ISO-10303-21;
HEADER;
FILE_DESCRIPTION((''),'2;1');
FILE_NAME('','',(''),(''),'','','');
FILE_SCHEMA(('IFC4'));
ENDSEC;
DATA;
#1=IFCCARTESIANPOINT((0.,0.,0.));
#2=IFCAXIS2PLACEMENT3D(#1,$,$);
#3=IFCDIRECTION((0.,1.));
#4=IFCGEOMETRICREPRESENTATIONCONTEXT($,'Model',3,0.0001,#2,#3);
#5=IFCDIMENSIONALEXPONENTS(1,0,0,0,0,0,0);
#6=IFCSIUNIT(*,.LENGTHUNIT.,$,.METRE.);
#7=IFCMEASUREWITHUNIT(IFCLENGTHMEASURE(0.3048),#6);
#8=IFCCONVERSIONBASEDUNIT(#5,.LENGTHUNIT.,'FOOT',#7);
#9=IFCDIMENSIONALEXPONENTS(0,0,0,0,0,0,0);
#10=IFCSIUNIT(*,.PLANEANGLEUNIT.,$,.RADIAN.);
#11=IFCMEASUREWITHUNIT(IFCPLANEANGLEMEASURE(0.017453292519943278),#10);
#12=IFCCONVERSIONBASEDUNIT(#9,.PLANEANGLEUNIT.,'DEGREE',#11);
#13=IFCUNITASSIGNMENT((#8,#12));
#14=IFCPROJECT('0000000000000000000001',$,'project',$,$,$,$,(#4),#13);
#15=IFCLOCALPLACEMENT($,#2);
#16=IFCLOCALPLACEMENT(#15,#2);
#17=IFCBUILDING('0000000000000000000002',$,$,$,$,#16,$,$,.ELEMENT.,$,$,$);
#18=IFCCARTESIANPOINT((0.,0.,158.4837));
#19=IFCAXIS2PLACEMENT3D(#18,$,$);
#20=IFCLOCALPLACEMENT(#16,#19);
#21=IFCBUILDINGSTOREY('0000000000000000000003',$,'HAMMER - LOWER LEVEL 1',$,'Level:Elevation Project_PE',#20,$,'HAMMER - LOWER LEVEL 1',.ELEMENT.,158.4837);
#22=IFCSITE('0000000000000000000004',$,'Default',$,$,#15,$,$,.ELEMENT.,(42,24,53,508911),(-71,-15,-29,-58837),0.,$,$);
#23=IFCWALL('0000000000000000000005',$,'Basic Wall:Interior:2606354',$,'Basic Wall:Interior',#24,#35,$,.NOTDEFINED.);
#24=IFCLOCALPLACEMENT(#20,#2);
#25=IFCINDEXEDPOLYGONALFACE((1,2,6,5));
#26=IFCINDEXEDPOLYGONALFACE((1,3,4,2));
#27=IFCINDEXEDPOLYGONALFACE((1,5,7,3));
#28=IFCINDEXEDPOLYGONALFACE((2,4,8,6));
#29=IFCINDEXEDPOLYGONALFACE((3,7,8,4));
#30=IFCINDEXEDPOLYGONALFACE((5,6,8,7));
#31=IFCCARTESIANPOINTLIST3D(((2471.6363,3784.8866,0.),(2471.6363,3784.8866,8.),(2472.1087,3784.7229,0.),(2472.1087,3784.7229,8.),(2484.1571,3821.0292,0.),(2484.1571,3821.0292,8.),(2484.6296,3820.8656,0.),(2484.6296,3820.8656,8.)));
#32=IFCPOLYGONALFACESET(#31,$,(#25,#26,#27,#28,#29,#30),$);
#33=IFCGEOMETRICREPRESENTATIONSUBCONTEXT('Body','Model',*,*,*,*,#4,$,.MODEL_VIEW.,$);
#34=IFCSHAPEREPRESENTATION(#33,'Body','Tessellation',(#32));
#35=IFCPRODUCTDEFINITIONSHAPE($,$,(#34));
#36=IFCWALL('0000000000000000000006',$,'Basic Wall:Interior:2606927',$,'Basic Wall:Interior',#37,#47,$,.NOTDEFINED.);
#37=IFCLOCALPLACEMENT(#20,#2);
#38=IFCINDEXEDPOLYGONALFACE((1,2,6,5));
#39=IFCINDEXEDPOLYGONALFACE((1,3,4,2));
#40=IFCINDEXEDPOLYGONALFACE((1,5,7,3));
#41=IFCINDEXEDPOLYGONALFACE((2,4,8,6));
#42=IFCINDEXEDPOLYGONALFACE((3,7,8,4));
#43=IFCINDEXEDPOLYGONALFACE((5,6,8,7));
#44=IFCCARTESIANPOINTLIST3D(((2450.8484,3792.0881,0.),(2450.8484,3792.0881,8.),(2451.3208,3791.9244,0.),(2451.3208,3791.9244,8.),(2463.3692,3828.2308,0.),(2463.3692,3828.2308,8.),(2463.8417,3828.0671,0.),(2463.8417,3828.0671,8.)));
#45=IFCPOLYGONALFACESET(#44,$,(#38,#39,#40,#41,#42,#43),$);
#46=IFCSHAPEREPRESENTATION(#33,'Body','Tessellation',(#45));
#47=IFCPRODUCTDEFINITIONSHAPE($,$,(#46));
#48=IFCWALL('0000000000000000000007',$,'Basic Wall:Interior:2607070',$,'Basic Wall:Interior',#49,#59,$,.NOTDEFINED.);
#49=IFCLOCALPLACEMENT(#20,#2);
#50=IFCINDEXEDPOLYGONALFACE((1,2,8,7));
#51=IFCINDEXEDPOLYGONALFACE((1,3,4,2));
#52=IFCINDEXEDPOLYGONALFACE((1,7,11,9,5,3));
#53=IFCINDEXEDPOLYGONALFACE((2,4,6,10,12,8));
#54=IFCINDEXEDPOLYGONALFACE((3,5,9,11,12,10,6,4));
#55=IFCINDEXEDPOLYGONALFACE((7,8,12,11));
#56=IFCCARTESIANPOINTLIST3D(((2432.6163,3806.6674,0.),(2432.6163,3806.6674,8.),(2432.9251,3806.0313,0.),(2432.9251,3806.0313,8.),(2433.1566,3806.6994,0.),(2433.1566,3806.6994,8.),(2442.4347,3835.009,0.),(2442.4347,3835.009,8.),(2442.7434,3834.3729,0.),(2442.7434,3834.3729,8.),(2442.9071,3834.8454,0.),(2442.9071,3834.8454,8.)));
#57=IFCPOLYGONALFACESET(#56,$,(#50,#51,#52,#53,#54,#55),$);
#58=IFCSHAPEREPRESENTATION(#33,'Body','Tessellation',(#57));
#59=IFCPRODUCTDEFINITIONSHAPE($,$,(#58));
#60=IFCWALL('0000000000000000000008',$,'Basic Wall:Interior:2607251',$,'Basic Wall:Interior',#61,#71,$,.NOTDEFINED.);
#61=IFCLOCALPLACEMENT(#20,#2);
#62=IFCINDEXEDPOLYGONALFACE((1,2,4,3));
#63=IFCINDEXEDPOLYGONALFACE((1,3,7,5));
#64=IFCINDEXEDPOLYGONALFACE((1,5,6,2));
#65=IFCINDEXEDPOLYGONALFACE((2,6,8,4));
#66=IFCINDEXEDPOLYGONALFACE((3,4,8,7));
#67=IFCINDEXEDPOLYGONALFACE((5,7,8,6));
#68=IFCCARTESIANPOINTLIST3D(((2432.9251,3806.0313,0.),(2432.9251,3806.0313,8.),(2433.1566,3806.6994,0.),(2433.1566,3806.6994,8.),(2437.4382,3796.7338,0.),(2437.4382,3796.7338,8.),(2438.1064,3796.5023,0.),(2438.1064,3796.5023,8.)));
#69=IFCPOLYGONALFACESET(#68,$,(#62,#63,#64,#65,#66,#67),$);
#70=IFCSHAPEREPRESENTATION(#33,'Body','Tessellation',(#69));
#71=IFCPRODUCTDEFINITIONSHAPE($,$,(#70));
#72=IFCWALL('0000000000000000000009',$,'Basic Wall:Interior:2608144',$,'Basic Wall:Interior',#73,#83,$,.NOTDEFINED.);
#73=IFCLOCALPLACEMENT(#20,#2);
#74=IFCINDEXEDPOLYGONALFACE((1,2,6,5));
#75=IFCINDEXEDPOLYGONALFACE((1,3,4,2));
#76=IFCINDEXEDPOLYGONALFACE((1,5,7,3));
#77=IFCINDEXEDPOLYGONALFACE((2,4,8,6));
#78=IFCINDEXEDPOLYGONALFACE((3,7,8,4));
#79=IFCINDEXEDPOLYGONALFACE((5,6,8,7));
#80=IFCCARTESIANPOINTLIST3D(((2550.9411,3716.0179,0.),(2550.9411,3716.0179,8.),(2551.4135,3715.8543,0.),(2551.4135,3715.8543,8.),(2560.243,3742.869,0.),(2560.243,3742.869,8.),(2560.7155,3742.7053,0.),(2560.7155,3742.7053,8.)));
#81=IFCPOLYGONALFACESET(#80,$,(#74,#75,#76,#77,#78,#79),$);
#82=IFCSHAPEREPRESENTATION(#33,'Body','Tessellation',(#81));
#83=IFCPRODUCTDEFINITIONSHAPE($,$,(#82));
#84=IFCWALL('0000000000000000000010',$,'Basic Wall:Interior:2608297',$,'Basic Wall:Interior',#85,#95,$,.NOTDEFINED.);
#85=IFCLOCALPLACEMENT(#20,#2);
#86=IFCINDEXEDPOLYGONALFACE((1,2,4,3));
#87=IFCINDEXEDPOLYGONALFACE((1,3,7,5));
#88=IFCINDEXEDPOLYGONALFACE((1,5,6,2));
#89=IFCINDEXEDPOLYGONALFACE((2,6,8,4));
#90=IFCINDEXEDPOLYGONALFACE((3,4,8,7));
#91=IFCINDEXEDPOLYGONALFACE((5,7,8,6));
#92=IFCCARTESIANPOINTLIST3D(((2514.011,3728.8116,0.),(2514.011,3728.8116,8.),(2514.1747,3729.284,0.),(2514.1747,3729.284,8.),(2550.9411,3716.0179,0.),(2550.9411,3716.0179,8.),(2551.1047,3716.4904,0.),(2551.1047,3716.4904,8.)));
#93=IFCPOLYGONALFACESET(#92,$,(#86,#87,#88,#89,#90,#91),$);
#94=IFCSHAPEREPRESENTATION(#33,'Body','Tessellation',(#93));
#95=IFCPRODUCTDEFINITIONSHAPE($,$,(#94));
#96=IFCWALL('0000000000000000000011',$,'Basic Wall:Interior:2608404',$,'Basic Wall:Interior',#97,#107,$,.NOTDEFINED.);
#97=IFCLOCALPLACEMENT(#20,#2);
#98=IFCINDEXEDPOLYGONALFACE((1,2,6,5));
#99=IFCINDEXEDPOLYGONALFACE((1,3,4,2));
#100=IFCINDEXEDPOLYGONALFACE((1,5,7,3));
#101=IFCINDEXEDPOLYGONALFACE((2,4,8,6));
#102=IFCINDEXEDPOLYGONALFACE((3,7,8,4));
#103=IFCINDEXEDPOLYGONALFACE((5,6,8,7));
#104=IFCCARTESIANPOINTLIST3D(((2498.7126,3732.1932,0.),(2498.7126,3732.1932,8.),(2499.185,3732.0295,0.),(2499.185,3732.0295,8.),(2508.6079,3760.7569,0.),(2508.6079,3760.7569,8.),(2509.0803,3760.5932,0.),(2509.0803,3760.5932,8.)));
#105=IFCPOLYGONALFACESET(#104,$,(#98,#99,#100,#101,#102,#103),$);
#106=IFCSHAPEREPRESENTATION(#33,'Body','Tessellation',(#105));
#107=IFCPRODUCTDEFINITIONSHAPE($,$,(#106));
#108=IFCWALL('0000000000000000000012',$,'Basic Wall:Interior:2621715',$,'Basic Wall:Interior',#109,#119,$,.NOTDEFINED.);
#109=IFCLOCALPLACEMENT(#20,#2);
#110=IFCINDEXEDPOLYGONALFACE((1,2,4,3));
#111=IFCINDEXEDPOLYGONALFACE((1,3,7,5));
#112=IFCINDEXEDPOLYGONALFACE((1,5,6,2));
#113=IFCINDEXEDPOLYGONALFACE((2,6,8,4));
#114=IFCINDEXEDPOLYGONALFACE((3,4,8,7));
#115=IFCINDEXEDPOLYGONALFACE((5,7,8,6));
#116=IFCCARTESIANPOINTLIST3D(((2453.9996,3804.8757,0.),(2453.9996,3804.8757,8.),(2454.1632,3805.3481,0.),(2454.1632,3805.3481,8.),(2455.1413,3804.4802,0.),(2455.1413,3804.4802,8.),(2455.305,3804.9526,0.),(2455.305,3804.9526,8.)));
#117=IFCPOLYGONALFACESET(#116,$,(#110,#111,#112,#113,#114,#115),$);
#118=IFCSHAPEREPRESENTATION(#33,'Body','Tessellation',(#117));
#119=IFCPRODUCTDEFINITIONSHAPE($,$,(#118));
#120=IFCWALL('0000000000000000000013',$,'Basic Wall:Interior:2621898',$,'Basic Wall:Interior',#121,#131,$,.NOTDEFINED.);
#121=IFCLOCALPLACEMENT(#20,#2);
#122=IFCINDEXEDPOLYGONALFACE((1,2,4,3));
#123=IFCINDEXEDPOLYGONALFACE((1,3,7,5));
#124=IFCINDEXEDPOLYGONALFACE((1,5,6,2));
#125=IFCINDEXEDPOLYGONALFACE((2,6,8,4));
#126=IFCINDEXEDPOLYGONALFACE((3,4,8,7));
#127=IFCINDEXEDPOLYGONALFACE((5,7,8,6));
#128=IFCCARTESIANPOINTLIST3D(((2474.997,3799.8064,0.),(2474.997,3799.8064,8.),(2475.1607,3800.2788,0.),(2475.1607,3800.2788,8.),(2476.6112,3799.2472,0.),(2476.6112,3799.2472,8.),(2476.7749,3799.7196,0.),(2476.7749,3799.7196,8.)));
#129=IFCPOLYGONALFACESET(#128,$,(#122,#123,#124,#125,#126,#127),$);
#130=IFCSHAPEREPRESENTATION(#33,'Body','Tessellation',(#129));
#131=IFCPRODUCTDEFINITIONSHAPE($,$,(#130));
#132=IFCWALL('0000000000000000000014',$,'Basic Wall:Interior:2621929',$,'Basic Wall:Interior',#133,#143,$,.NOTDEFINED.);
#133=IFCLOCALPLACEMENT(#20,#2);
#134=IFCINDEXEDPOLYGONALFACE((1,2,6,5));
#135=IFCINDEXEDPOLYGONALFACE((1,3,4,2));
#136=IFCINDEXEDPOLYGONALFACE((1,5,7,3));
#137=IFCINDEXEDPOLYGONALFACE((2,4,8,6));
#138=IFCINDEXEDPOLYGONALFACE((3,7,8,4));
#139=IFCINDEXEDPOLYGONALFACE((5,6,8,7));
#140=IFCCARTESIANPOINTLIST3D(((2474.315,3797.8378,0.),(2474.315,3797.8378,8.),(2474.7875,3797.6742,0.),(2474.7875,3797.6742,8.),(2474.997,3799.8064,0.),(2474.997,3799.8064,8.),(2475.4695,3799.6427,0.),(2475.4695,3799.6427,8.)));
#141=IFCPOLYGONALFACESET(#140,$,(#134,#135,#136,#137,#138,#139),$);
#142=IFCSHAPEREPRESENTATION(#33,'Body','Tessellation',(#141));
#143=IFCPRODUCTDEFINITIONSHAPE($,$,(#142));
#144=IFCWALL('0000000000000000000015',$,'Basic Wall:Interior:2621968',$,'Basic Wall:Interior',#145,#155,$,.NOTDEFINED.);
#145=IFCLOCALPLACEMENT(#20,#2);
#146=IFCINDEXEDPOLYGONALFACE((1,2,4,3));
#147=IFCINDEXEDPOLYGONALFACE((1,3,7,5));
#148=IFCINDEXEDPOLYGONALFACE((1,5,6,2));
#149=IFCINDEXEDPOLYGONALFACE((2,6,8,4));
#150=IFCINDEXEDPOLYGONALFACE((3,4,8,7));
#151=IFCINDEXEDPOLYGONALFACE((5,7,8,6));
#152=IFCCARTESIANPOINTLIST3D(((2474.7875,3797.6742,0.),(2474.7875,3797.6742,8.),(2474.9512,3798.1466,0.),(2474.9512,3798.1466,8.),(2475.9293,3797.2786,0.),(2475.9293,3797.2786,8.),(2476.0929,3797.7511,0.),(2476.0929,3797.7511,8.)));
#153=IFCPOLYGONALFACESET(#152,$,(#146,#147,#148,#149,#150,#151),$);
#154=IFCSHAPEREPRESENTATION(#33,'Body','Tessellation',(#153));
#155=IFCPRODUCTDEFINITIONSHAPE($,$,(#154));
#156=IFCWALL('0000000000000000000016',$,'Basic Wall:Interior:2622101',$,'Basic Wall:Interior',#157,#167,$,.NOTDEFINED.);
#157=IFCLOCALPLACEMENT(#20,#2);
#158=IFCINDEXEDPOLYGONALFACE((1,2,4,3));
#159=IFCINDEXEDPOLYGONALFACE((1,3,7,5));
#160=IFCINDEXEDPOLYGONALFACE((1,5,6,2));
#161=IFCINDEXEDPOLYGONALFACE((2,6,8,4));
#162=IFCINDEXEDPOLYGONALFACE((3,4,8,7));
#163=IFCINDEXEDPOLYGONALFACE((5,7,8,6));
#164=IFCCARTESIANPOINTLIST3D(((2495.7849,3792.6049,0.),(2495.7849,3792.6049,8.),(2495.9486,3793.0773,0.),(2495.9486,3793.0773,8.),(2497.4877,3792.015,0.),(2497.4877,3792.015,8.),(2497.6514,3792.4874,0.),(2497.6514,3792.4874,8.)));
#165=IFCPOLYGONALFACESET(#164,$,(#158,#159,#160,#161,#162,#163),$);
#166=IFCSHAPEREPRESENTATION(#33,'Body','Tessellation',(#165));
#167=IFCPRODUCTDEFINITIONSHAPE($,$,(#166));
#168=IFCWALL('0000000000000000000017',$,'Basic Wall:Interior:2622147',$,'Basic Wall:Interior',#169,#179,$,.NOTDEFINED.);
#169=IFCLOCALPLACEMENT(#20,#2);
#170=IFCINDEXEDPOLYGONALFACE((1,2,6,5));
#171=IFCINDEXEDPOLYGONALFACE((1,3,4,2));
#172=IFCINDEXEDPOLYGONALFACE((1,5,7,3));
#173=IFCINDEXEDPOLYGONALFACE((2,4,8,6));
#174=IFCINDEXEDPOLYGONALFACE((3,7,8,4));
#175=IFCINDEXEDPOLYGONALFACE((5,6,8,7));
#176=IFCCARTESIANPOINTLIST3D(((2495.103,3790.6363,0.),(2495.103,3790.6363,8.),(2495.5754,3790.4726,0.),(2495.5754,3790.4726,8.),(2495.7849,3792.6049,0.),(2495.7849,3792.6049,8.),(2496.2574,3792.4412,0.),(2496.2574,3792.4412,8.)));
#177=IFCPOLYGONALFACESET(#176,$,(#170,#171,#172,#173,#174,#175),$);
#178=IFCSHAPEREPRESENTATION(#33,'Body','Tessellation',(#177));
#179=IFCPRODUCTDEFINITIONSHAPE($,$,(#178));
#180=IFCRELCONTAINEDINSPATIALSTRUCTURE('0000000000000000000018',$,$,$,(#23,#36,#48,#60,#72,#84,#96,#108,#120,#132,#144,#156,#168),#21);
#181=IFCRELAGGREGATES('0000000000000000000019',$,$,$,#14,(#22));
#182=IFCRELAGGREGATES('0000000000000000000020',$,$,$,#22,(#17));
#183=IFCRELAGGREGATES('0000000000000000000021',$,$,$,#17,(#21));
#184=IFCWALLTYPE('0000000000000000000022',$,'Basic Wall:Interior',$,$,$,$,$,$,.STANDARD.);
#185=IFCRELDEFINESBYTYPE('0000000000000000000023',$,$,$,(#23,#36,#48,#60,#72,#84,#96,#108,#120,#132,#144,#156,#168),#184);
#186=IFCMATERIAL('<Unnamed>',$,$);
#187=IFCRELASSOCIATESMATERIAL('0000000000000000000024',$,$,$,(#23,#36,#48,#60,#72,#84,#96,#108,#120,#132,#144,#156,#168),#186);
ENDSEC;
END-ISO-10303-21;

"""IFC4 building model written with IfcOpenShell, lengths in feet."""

from ifc_helpers import new_model, entity, si_unit, converted_unit, direction, frame, origin, place, context, subcontext, project, spatial, indexed_curve, outline, extrude, material, type_object, element, save


model = new_model("IFC4")

# Units and contexts
model_context = context("Model", 3, precision=0.0001, world=origin(), true_north=direction((0.0, 1.0)))
body_context = subcontext(model_context, "Body", "Model", "MODEL_VIEW")
ifc_project = project(units=[converted_unit("LENGTHUNIT", "FOOT", entity("IfcLengthMeasure", 0.3048), si_unit("LENGTHUNIT", "METRE"), dimensions=[1, 0, 0, 0, 0, 0, 0]), converted_unit("PLANEANGLEUNIT", "DEGREE", entity("IfcPlaneAngleMeasure", 0.017453292519943278), si_unit("PLANEANGLEUNIT", "RADIAN"), dimensions=[0, 0, 0, 0, 0, 0, 0])], contexts=[model_context])

# Site, building, storey
site_placement = place(None, origin())
site = spatial("IfcSite", under=ifc_project, at=site_placement, Name="Default", CompositionType="ELEMENT", RefLatitude=(42, 24, 53, 508911), RefLongitude=(-71, -15, -29, -58837), RefElevation=0.0)
building_placement = place(site_placement, origin())
building = spatial("IfcBuilding", under=site, at=building_placement, CompositionType="ELEMENT")
storey_placement = place(building_placement, frame((0.0, 0.0, 158.4837)))
storey = spatial("IfcBuildingStorey", under=building, at=storey_placement, Name="HAMMER - LOWER LEVEL 1", ObjectType="Level:Elevation Project_PE", LongName="HAMMER - LOWER LEVEL 1", CompositionType="ELEMENT", Elevation=158.4837)

# Walls
ifc_material_1 = material(Name="<Unnamed>")
wall_type = type_object("IfcWallType", Name="Basic Wall:Interior", PredefinedType="STANDARD")
wall_1_placement = place(storey_placement, frame((2471.8725, 3784.8047, 0.0), z_axis=(0.0, 0.0, 1.0), x_axis=(0.327342, 0.944906, 0.0)))
element("IfcWall", 1, at=wall_1_placement, inside=storey, type_object=wall_type, material=ifc_material_1, Name="Basic Wall:Interior:2606354", ObjectType="Basic Wall:Interior", PredefinedType="NOTDEFINED", context=body_context, shape_type="SweptSolid", body=[
    extrude(outline(indexed_curve([(38.25, 0.25), (0.0, 0.25), (0.0, -0.25), (38.25, -0.25), (38.25, 0.25)], self_intersect=False)), origin(), (0.0, 0.0, 1.0), 8.0),
])
wall_2_placement = place(storey_placement, frame((2451.0846, 3792.0063, 0.0), z_axis=(0.0, 0.0, 1.0), x_axis=(0.327342, 0.944906, 0.0)))
element("IfcWall", 2, at=wall_2_placement, inside=storey, type_object=wall_type, material=ifc_material_1, Name="Basic Wall:Interior:2606927", ObjectType="Basic Wall:Interior", PredefinedType="NOTDEFINED", context=body_context, shape_type="SweptSolid", body=[
    extrude(outline(indexed_curve([(38.25, 0.25), (0.0, 0.25), (0.0, -0.25), (38.25, -0.25), (38.25, 0.25)], self_intersect=False)), origin(), (0.0, 0.0, 1.0), 8.0),
])
wall_3_placement = place(storey_placement, frame((2432.6889, 3806.1131, 0.0), z_axis=(0.0, 0.0, 1.0), x_axis=(0.327342, 0.944906, 0.0)))
element("IfcWall", 3, at=wall_3_placement, inside=storey, type_object=wall_type, material=ifc_material_1, Name="Basic Wall:Interior:2607070", ObjectType="Basic Wall:Interior", PredefinedType="NOTDEFINED", context=body_context, shape_type="SweptSolid", body=[
    extrude(outline(indexed_curve([(30.4941, -0.25), (30.4941, 0.25), (0.5, 0.25), (0.0, -0.25), (0.7071, -0.25), (29.9941, -0.25), (30.4941, -0.25)], self_intersect=False)), origin(), (0.0, 0.0, 1.0), 8.0),
])
wall_4_placement = place(storey_placement, frame((2437.8815, 3796.3931, 0.0), z_axis=(0.0, 0.0, 1.0), x_axis=(-0.436683, 0.899615, 0.0)))
element("IfcWall", 4, at=wall_4_placement, inside=storey, type_object=wall_type, material=ifc_material_1, Name="Basic Wall:Interior:2607251", ObjectType="Basic Wall:Interior", PredefinedType="NOTDEFINED", context=body_context, shape_type="SweptSolid", body=[
    extrude(outline(indexed_curve([(11.335, -0.25), (10.835, 0.25), (0.5, 0.25), (0.0, -0.25), (11.335, -0.25)], self_intersect=False)), origin(), (0.0, 0.0, 1.0), 8.0),
])
wall_5_placement = place(storey_placement, frame((2560.4793, 3742.7872, 0.0), z_axis=(0.0, 0.0, 1.0), x_axis=(-0.327342, -0.944906, 0.0)))
element("IfcWall", 5, at=wall_5_placement, inside=storey, type_object=wall_type, material=ifc_material_1, Name="Basic Wall:Interior:2608144", ObjectType="Basic Wall:Interior", PredefinedType="NOTDEFINED", context=body_context, shape_type="SweptSolid", body=[
    extrude(outline(indexed_curve([(28.4167, 0.25), (0.0, 0.25), (0.0, -0.25), (28.4167, -0.25), (28.4167, 0.25)], self_intersect=False)), origin(), (0.0, 0.0, 1.0), 8.0),
])
wall_6_placement = place(storey_placement, frame((2551.0229, 3716.2541, 0.0), z_axis=(0.0, 0.0, 1.0), x_axis=(-0.944906, 0.327342, 0.0)))
element("IfcWall", 6, at=wall_6_placement, inside=storey, type_object=wall_type, material=ifc_material_1, Name="Basic Wall:Interior:2608297", ObjectType="Basic Wall:Interior", PredefinedType="NOTDEFINED", context=body_context, shape_type="SweptSolid", body=[
    extrude(outline(indexed_curve([(39.0833, 0.25), (0.0, 0.25), (0.0, -0.25), (39.0833, -0.25), (39.0833, 0.25)], self_intersect=False)), origin(), (0.0, 0.0, 1.0), 8.0),
])
wall_7_placement = place(storey_placement, frame((2498.9488, 3732.1113, 0.0), z_axis=(0.0, 0.0, 1.0), x_axis=(0.327342, 0.944906, 0.0)))
element("IfcWall", 7, at=wall_7_placement, inside=storey, type_object=wall_type, material=ifc_material_1, Name="Basic Wall:Interior:2608404", ObjectType="Basic Wall:Interior", PredefinedType="NOTDEFINED", context=body_context, shape_type="SweptSolid", body=[
    extrude(outline(indexed_curve([(30.2292, 0.25), (0.0, 0.25), (0.0, -0.25), (30.2292, -0.25), (30.2292, 0.25)], self_intersect=False)), origin(), (0.0, 0.0, 1.0), 8.0),
])
wall_8_placement = place(storey_placement, frame((2454.0814, 3805.1119, 0.0), z_axis=(0.0, 0.0, 1.0), x_axis=(0.944906, -0.327342, 0.0)))
element("IfcWall", 8, at=wall_8_placement, inside=storey, type_object=wall_type, material=ifc_material_1, Name="Basic Wall:Interior:2621715", ObjectType="Basic Wall:Interior", PredefinedType="NOTDEFINED", context=body_context, shape_type="SweptSolid", body=[
    extrude(outline(indexed_curve([(1.2083, 0.25), (0.0, 0.25), (0.0, -0.25), (1.2083, -0.25), (1.2083, 0.25)], self_intersect=False)), origin(), (0.0, 0.0, 1.0), 8.0),
])
wall_9_placement = place(storey_placement, frame((2476.6931, 3799.4834, 0.0), z_axis=(0.0, 0.0, 1.0), x_axis=(-0.944906, 0.327342, 0.0)))
element("IfcWall", 9, at=wall_9_placement, inside=storey, type_object=wall_type, material=ifc_material_1, Name="Basic Wall:Interior:2621898", ObjectType="Basic Wall:Interior", PredefinedType="NOTDEFINED", context=body_context, shape_type="SweptSolid", body=[
    extrude(outline(indexed_curve([(1.7083, 0.25), (0.0, 0.25), (0.0, -0.25), (1.7083, -0.25), (1.7083, 0.25)], self_intersect=False)), origin(), (0.0, 0.0, 1.0), 8.0),
])
wall_10_placement = place(storey_placement, frame((2475.2332, 3799.7245, 0.0), z_axis=(0.0, 0.0, 1.0), x_axis=(-0.327342, -0.944906, 0.0)))
element("IfcWall", 10, at=wall_10_placement, inside=storey, type_object=wall_type, material=ifc_material_1, Name="Basic Wall:Interior:2621929", ObjectType="Basic Wall:Interior", PredefinedType="NOTDEFINED", context=body_context, shape_type="SweptSolid", body=[
    extrude(outline(indexed_curve([(2.0833, 0.25), (0.0, 0.25), (0.0, -0.25), (2.0833, -0.25), (2.0833, 0.25)], self_intersect=False)), origin(), (0.0, 0.0, 1.0), 8.0),
])
wall_11_placement = place(storey_placement, frame((2474.8693, 3797.9104, 0.0), z_axis=(0.0, 0.0, 1.0), x_axis=(0.944906, -0.327342, 0.0)))
element("IfcWall", 11, at=wall_11_placement, inside=storey, type_object=wall_type, material=ifc_material_1, Name="Basic Wall:Interior:2621968", ObjectType="Basic Wall:Interior", PredefinedType="NOTDEFINED", context=body_context, shape_type="SweptSolid", body=[
    extrude(outline(indexed_curve([(1.2083, 0.25), (0.0, 0.25), (0.0, -0.25), (1.2083, -0.25), (1.2083, 0.25)], self_intersect=False)), origin(), (0.0, 0.0, 1.0), 8.0),
])
wall_12_placement = place(storey_placement, frame((2497.5696, 3792.2512, 0.0), z_axis=(0.0, 0.0, 1.0), x_axis=(-0.944906, 0.327342, 0.0)))
element("IfcWall", 12, at=wall_12_placement, inside=storey, type_object=wall_type, material=ifc_material_1, Name="Basic Wall:Interior:2622101", ObjectType="Basic Wall:Interior", PredefinedType="NOTDEFINED", context=body_context, shape_type="SweptSolid", body=[
    extrude(outline(indexed_curve([(1.8021, 0.25), (0.0, 0.25), (0.0, -0.25), (1.8021, -0.25), (1.8021, 0.25)], self_intersect=False)), origin(), (0.0, 0.0, 1.0), 8.0),
])
wall_13_placement = place(storey_placement, frame((2496.0212, 3792.523, 0.0), z_axis=(0.0, 0.0, 1.0), x_axis=(-0.327342, -0.944906, 0.0)))
element("IfcWall", 13, at=wall_13_placement, inside=storey, type_object=wall_type, material=ifc_material_1, Name="Basic Wall:Interior:2622147", ObjectType="Basic Wall:Interior", PredefinedType="NOTDEFINED", context=body_context, shape_type="SweptSolid", body=[
    extrude(outline(indexed_curve([(2.0833, 0.25), (0.0, 0.25), (0.0, -0.25), (2.0833, -0.25), (2.0833, 0.25)], self_intersect=False)), origin(), (0.0, 0.0, 1.0), 8.0),
])

save(model, "model.ifc")
